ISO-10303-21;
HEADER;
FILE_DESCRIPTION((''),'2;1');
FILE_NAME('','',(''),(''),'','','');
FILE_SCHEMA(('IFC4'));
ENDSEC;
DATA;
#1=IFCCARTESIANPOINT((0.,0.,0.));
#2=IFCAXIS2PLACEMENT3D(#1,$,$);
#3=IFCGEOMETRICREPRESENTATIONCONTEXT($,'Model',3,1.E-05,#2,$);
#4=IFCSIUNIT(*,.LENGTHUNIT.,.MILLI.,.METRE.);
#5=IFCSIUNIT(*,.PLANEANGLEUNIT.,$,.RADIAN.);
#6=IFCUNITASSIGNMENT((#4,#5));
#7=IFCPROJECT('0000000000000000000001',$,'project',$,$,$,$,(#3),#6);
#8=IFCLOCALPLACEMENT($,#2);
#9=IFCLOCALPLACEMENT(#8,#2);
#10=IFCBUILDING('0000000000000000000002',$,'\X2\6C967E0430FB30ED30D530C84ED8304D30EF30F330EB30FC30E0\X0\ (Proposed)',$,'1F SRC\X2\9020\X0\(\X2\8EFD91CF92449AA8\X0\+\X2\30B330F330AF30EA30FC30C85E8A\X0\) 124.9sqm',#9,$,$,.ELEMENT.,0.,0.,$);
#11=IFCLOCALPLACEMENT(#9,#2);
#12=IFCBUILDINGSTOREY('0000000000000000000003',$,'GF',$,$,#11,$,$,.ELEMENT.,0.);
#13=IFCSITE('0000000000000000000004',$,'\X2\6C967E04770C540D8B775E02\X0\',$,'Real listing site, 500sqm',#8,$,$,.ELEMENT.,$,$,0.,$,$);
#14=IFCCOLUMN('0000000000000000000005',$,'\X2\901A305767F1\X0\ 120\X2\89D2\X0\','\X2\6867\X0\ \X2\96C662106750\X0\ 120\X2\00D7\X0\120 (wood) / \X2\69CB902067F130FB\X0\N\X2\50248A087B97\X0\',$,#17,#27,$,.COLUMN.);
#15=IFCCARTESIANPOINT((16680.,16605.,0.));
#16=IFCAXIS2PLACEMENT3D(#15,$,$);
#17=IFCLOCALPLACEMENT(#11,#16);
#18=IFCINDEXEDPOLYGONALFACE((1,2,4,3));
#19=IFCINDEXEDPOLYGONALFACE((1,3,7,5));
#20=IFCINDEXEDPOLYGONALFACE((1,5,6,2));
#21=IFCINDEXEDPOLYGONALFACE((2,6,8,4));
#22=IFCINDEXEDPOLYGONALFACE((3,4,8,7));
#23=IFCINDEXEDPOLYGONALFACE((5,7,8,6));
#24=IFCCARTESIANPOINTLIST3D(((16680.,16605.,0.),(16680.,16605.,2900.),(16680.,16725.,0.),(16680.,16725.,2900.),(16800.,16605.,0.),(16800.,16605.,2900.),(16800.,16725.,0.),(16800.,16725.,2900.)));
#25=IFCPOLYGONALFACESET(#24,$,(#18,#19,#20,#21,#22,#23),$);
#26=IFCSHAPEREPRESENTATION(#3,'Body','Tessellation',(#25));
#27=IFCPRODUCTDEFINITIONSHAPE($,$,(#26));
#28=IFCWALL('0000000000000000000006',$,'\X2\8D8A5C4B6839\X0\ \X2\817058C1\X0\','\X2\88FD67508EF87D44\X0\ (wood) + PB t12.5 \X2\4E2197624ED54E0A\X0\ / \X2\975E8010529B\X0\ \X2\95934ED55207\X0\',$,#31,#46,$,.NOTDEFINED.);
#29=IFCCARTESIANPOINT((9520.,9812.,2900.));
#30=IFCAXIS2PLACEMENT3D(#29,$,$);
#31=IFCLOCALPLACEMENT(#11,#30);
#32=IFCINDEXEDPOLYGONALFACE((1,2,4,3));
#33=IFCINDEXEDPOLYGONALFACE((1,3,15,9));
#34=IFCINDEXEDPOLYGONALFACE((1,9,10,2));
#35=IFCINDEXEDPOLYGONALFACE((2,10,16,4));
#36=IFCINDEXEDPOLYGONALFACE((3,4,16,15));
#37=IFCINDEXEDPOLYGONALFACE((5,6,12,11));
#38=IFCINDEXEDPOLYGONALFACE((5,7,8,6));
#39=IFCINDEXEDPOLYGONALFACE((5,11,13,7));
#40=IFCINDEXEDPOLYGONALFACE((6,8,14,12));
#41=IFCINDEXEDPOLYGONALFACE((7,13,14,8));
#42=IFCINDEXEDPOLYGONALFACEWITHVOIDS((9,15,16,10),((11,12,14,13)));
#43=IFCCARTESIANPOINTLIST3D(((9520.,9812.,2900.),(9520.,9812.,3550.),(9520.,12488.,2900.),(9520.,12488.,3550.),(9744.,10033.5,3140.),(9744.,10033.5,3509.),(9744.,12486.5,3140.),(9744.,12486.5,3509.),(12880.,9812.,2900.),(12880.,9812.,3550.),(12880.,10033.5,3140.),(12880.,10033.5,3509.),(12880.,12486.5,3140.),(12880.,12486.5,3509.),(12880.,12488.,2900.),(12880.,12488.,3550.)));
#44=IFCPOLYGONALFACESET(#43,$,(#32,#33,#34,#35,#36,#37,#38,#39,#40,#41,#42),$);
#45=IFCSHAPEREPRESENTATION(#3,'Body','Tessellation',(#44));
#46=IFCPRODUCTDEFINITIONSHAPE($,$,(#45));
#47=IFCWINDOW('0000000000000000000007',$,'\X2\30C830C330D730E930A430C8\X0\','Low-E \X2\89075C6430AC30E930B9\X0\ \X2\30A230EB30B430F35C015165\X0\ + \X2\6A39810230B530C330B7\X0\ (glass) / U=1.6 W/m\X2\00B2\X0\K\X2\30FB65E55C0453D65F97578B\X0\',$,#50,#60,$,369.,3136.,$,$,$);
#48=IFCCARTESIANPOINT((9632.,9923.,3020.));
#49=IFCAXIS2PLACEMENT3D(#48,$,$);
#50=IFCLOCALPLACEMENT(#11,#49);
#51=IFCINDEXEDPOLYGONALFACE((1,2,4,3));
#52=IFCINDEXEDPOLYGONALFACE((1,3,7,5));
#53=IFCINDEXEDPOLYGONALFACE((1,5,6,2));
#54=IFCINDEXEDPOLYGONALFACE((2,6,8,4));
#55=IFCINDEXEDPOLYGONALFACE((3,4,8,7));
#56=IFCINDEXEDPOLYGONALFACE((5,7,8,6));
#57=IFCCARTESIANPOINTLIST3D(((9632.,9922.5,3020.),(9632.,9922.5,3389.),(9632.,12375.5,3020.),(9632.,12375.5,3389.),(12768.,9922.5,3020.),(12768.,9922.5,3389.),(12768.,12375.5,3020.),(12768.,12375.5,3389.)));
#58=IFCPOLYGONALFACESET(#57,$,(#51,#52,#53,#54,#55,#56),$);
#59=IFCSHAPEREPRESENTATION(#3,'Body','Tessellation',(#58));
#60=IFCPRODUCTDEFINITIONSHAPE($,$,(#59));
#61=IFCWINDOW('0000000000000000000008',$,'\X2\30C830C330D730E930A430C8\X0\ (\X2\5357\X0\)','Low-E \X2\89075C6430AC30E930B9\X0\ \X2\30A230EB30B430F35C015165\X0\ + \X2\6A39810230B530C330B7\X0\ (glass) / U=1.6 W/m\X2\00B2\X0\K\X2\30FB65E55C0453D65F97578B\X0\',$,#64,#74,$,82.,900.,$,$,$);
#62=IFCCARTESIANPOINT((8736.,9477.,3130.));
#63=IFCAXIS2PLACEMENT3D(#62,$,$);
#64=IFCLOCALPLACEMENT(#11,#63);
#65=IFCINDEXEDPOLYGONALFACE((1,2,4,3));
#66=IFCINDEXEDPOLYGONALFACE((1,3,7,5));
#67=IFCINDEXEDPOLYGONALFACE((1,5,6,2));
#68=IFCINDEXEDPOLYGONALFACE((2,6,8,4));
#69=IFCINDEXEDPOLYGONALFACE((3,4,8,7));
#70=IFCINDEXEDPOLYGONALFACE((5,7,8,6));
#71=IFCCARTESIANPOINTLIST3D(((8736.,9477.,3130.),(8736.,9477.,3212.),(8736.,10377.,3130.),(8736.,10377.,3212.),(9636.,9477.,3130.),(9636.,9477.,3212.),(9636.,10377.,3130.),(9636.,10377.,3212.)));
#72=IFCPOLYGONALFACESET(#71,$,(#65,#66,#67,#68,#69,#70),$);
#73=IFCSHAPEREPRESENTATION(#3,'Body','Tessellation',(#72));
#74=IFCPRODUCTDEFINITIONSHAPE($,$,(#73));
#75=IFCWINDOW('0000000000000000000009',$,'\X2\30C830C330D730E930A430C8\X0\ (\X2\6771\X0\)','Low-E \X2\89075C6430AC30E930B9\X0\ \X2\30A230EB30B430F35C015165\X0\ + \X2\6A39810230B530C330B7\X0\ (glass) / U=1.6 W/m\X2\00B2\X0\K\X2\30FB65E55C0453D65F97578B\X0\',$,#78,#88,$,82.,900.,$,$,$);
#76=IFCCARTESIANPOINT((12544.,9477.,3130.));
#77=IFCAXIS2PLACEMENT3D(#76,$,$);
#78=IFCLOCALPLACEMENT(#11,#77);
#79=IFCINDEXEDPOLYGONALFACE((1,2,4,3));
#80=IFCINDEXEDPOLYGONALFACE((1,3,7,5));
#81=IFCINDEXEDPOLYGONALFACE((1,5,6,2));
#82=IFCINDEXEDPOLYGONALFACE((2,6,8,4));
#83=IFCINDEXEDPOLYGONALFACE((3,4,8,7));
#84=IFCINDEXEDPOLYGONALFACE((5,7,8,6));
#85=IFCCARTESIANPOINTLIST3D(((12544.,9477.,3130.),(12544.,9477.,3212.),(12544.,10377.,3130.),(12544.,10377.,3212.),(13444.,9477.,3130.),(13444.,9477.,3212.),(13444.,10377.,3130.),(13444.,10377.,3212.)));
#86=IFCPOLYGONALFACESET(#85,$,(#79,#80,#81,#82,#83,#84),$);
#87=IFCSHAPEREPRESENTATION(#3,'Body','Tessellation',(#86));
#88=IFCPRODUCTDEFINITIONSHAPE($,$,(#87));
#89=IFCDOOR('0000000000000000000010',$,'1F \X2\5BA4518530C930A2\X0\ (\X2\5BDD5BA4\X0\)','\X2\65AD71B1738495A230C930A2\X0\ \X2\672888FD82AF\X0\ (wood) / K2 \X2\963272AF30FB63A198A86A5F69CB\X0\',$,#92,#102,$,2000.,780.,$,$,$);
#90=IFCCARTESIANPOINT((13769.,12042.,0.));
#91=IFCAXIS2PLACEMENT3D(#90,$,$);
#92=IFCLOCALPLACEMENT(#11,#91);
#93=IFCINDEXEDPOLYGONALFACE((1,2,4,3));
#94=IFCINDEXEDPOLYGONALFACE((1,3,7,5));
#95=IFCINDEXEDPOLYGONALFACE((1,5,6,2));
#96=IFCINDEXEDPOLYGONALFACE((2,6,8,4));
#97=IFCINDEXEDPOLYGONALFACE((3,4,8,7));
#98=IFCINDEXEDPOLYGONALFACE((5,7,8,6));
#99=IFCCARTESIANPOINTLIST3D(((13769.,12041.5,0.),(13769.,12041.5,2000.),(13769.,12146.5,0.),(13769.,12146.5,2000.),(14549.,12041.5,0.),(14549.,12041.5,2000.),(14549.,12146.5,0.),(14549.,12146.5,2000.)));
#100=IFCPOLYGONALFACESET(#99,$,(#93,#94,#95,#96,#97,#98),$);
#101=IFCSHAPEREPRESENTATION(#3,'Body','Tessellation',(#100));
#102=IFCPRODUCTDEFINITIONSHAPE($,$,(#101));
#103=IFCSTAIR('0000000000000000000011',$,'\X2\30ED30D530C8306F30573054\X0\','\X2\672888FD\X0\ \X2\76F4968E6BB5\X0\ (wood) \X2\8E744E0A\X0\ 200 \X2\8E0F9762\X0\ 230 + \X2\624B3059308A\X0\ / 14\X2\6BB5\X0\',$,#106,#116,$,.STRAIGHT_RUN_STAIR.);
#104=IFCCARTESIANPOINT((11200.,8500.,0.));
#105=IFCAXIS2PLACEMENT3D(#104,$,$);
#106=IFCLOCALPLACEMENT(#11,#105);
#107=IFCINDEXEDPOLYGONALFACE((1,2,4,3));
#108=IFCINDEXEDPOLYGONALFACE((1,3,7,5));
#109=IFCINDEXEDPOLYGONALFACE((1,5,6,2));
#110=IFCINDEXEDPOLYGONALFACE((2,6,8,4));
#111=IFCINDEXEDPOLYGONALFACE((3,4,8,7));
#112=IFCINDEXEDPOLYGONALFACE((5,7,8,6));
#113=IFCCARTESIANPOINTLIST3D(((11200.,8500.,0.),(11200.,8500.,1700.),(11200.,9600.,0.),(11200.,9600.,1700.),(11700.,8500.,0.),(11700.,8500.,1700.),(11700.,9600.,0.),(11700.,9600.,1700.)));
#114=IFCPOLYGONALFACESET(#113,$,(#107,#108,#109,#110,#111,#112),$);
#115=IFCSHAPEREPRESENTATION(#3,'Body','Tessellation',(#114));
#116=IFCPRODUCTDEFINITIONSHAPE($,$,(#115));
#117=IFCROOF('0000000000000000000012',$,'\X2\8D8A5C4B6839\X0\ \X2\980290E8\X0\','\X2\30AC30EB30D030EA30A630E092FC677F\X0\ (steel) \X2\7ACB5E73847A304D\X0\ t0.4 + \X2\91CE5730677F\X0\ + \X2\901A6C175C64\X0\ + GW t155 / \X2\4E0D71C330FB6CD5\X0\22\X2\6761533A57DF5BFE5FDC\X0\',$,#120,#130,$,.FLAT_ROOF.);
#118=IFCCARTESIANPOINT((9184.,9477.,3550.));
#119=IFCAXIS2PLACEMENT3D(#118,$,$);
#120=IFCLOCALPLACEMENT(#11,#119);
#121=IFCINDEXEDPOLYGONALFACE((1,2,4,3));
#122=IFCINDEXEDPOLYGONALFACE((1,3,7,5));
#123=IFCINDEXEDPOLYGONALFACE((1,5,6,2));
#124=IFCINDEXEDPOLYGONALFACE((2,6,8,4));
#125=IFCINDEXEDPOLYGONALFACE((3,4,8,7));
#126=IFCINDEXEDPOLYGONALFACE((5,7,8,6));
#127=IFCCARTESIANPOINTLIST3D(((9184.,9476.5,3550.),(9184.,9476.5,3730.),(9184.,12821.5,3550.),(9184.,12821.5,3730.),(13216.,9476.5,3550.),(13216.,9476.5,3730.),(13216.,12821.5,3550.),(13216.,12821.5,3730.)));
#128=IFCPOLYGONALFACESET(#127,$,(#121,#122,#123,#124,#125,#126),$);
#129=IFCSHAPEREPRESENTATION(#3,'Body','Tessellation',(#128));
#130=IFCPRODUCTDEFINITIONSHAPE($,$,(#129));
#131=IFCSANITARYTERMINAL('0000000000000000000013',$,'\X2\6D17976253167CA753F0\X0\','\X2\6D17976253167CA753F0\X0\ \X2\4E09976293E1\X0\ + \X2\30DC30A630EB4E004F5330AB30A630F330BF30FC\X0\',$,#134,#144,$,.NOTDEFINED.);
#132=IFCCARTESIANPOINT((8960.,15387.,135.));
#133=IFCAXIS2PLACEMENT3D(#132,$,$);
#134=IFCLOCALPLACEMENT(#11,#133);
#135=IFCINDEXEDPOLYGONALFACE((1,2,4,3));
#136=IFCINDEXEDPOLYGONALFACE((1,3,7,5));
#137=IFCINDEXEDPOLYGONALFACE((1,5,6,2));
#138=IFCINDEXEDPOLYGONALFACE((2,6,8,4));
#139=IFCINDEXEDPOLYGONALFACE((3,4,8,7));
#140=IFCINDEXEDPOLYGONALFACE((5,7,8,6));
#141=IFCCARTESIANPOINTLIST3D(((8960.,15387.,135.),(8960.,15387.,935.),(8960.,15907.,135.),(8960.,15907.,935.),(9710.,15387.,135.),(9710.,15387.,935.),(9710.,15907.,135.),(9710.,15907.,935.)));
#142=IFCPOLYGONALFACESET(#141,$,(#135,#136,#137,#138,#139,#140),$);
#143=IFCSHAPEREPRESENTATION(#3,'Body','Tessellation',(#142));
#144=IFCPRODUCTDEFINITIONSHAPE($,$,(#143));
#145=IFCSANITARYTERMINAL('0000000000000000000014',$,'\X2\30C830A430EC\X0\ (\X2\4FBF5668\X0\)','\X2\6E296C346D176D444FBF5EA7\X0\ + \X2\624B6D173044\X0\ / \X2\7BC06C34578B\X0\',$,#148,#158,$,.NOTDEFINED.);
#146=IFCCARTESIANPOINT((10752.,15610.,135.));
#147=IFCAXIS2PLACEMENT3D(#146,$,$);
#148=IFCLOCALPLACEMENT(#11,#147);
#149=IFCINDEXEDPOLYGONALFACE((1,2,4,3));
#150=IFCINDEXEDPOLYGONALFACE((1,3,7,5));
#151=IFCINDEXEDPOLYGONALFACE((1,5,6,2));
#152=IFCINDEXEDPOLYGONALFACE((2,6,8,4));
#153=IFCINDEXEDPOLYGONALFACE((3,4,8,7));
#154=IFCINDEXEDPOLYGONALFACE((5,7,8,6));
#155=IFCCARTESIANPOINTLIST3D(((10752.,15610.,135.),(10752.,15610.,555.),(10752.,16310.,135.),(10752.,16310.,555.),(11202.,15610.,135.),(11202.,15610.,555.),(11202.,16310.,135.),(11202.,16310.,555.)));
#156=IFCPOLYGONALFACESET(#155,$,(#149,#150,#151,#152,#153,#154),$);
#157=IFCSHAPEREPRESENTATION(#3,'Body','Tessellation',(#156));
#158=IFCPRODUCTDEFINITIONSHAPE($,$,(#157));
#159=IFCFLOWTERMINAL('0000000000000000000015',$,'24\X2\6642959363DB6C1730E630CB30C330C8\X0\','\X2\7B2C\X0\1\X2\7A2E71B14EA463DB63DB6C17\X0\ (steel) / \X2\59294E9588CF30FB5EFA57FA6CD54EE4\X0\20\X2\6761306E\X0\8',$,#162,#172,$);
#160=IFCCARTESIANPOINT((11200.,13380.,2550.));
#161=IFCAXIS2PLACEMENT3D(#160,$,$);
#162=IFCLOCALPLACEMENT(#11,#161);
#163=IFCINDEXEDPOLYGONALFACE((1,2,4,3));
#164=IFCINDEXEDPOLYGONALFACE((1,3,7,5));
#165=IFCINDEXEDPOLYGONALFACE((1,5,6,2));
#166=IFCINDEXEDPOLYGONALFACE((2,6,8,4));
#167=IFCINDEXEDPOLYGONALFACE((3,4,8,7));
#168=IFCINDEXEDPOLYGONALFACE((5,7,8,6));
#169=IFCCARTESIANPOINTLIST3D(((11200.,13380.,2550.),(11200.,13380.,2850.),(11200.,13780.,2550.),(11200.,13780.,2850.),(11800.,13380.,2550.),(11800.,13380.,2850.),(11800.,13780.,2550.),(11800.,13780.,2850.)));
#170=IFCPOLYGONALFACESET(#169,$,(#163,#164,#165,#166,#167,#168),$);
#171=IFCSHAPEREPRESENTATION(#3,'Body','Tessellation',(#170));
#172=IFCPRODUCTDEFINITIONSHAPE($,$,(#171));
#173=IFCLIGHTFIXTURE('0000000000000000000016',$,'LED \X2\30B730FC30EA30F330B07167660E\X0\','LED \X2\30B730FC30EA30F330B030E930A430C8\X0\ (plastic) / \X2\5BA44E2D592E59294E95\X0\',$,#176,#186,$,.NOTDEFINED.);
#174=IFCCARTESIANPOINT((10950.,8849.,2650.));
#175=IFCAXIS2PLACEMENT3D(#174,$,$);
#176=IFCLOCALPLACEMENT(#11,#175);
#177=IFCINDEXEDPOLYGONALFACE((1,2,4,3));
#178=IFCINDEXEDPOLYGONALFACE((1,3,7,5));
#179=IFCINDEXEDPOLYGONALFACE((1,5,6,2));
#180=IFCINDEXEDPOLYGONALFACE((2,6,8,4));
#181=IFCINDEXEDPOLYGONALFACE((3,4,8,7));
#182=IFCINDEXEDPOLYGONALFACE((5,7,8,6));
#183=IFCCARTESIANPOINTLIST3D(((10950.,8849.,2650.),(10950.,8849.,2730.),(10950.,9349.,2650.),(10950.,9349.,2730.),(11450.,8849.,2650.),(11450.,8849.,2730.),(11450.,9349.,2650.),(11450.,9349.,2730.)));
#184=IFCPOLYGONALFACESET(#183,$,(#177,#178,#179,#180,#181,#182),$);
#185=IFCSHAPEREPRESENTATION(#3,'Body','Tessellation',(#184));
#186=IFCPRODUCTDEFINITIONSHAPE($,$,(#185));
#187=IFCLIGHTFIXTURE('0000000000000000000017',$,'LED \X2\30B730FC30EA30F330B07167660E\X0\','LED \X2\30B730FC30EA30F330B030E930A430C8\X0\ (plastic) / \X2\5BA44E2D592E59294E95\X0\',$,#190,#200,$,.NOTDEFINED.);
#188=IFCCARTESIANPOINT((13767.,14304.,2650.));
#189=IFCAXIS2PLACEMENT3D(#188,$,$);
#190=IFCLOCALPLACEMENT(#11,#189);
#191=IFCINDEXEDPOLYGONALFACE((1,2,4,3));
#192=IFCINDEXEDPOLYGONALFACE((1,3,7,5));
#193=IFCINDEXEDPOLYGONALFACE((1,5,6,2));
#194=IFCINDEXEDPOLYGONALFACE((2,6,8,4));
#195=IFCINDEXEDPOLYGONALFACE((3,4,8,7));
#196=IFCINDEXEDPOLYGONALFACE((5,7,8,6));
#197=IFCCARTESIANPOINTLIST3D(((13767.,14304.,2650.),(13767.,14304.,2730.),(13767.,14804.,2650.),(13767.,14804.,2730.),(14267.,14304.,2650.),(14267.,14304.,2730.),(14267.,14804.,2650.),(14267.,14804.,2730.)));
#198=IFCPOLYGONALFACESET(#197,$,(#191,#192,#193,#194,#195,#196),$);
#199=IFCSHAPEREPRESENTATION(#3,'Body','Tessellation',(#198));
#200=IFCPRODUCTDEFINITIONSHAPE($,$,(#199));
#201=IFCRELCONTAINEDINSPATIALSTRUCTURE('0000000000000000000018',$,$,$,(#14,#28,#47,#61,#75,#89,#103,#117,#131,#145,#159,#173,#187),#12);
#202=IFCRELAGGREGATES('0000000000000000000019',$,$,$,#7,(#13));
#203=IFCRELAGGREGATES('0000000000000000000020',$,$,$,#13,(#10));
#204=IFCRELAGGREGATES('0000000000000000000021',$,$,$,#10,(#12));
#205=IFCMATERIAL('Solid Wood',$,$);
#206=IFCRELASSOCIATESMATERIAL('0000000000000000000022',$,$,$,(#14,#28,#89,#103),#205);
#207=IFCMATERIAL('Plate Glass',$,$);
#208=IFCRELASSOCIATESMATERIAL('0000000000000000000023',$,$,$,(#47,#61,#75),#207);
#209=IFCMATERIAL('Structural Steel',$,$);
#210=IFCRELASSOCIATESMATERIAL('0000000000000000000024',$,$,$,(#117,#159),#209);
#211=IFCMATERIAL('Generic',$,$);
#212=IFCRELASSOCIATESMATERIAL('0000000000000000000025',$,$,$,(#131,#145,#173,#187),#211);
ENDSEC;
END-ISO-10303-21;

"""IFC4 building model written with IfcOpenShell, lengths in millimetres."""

from ifc_helpers import new_model, si_unit, frame, frame_2d, origin, place, context, project, spatial, rectangle, extrude, material, element, fill, save


model = new_model("IFC4")

# Units and contexts
model_context = context("Model", 3, precision=1e-05, world=origin())
ifc_project = project(units=[si_unit("LENGTHUNIT", "METRE", prefix="MILLI"), si_unit("PLANEANGLEUNIT", "RADIAN")], contexts=[model_context])

# Site, building, storey
site_placement = place(None, origin())
site = spatial("IfcSite", under=ifc_project, at=site_placement, Name="沖縄県名護市", ObjectType="Real listing site, 500sqm", CompositionType="ELEMENT", RefElevation=0.0)
building_placement = place(site_placement, origin())
building = spatial("IfcBuilding", under=site, at=building_placement, Name="沖縄・ロフト付きワンルーム (Proposed)", ObjectType="1F SRC造(軽量鉄骨+コンクリート床) 124.9sqm", CompositionType="ELEMENT", ElevationOfRefHeight=0.0, ElevationOfTerrain=0.0)
storey_placement = place(building_placement, origin())
storey = spatial("IfcBuildingStorey", under=building, at=storey_placement, Name="GF", CompositionType="ELEMENT", Elevation=0.0)

# Column
ifc_material_1 = material(Name="Solid Wood")
column_1_placement = place(storey_placement, frame((16680.0, 16605.0, 0.0)))
element("IfcColumn", 1, at=column_1_placement, inside=storey, material=ifc_material_1, Name="通し柱 120角", Description="桧 集成材 120×120 (wood) / 構造柱・N値計算", PredefinedType="COLUMN", context=model_context, shape_type="SweptSolid", body=[
    extrude(rectangle(XDim=120.0, YDim=120.0, at=frame_2d((60.0, 60.0))), frame((16680.0, 16605.0, 0.0)), (0.0, 0.0, 1.0), 2900.0),
])

# Wall, openings, windows
wall_1_placement = place(storey_placement, frame((9520.0, 9812.0, 2900.0)))
wall_1 = element("IfcWall", 2, at=wall_1_placement, inside=storey, material=ifc_material_1, Name="越屋根 腰壁", Description="製材軸組 (wood) + PB t12.5 両面仕上 / 非耐力 間仕切", PredefinedType="NOTDEFINED", context=model_context, shape_type="SweptSolid", body=[
    extrude(rectangle(XDim=3360.0, YDim=2676.0, at=frame_2d((1680.0, 1338.0))), frame((9520.0, 9812.0, 2900.0)), (0.0, 0.0, 1.0), 650.0),
])
opening_1_placement = place(storey_placement, frame((9632.0, 9923.0, 3020.0)))
opening_1 = element("IfcOpeningElement", 3, at=opening_1_placement, cuts=wall_1, PredefinedType="NOTDEFINED", context=model_context, shape_type="SweptSolid", body=[
    extrude(rectangle(XDim=3136.0, YDim=2453.0, at=frame_2d((1568.0, 1226.0))), frame((9632.0, 9923.0, 3020.0)), (0.0, 0.0, 1.0), 369.0),
])
opening_2_placement = place(storey_placement, frame((8736.0, 9477.0, 3130.0)))
opening_2 = element("IfcOpeningElement", 4, at=opening_2_placement, cuts=wall_1, PredefinedType="NOTDEFINED", context=model_context, shape_type="SweptSolid", body=[
    extrude(rectangle(XDim=900.0, YDim=900.0, at=frame_2d((450.0, 450.0))), frame((8736.0, 9477.0, 3130.0)), (0.0, 0.0, 1.0), 82.0),
])
opening_3_placement = place(storey_placement, frame((12544.0, 9477.0, 3130.0)))
opening_3 = element("IfcOpeningElement", 5, at=opening_3_placement, cuts=wall_1, PredefinedType="NOTDEFINED", context=model_context, shape_type="SweptSolid", body=[
    extrude(rectangle(XDim=900.0, YDim=900.0, at=frame_2d((450.0, 450.0))), frame((12544.0, 9477.0, 3130.0)), (0.0, 0.0, 1.0), 82.0),
])
ifc_material_2 = material(Name="Plate Glass")
window_1_placement = place(storey_placement, frame((9632.0, 9923.0, 3020.0)))
window_1 = element("IfcWindow", 6, at=window_1_placement, inside=storey, material=ifc_material_2, Name="トップライト", Description="Low-E 複層ガラス アルゴン封入 + 樹脂サッシ (glass) / U=1.6 W/m²K・日射取得型", OverallHeight=369.0, OverallWidth=3136.0, context=model_context, shape_type="SweptSolid", body=[
    extrude(rectangle(XDim=3136.0, YDim=2453.0, at=frame_2d((1568.0, 1226.0))), frame((9632.0, 9923.0, 3020.0)), (0.0, 0.0, 1.0), 369.0),
])
fill(opening_1, window_1)
window_2_placement = place(storey_placement, frame((8736.0, 9477.0, 3130.0)))
window_2 = element("IfcWindow", 7, at=window_2_placement, inside=storey, material=ifc_material_2, Name="トップライト (南)", Description="Low-E 複層ガラス アルゴン封入 + 樹脂サッシ (glass) / U=1.6 W/m²K・日射取得型", OverallHeight=82.0, OverallWidth=900.0, context=model_context, shape_type="SweptSolid", body=[
    extrude(rectangle(XDim=900.0, YDim=900.0, at=frame_2d((450.0, 450.0))), frame((8736.0, 9477.0, 3130.0)), (0.0, 0.0, 1.0), 82.0),
])
fill(opening_2, window_2)
window_3_placement = place(storey_placement, frame((12544.0, 9477.0, 3130.0)))
window_3 = element("IfcWindow", 8, at=window_3_placement, inside=storey, material=ifc_material_2, Name="トップライト (東)", Description="Low-E 複層ガラス アルゴン封入 + 樹脂サッシ (glass) / U=1.6 W/m²K・日射取得型", OverallHeight=82.0, OverallWidth=900.0, context=model_context, shape_type="SweptSolid", body=[
    extrude(rectangle(XDim=900.0, YDim=900.0, at=frame_2d((450.0, 450.0))), frame((12544.0, 9477.0, 3130.0)), (0.0, 0.0, 1.0), 82.0),
])
fill(opening_3, window_3)

# Door
door_placement = place(storey_placement, frame((13769.0, 12042.0, 0.0)))
element("IfcDoor", 9, at=door_placement, inside=storey, material=ifc_material_1, Name="1F 室内ドア (寝室)", Description="断熱玄関ドア 木製芯 (wood) / K2 防犯・採風機構", OverallHeight=2000.0, OverallWidth=780.0, context=model_context, shape_type="SweptSolid", body=[
    extrude(rectangle(XDim=780.0, YDim=105.0, at=frame_2d((390.0, 52.0))), frame((13769.0, 12042.0, 0.0)), (0.0, 0.0, 1.0), 2000.0),
])

# Stair
stair_placement = place(storey_placement, frame((11200.0, 8500.0, 0.0)))
element("IfcStair", 10, at=stair_placement, inside=storey, material=ifc_material_1, Name="ロフトはしご", Description="木製 直階段 (wood) 蹴上 200 踏面 230 + 手すり / 14段", PredefinedType="STRAIGHT_RUN_STAIR", context=model_context, shape_type="SweptSolid", body=[
    extrude(rectangle(XDim=500.0, YDim=1100.0, at=frame_2d((250.0, 550.0))), frame((11200.0, 8500.0, 0.0)), (0.0, 0.0, 1.0), 1700.0),
])

# Roof
ifc_material_3 = material(Name="Structural Steel")
roof_placement = place(storey_placement, frame((9184.0, 9477.0, 3550.0)))
element("IfcRoof", 11, at=roof_placement, inside=storey, material=ifc_material_3, Name="越屋根 頂部", Description="ガルバリウム鋼板 (steel) 立平葺き t0.4 + 野地板 + 通気層 + GW t155 / 不燃・法22条区域対応", PredefinedType="FLAT_ROOF", context=model_context, shape_type="SweptSolid", body=[
    extrude(rectangle(XDim=4032.0, YDim=3345.0, at=frame_2d((2016.0, 1672.0))), frame((9184.0, 9477.0, 3550.0)), (0.0, 0.0, 1.0), 180.0),
])

# Sanitary terminals
ifc_material_4 = material(Name="Generic")
sanitary_terminal_1_placement = place(storey_placement, frame((8960.0, 15387.0, 135.0)))
element("IfcSanitaryTerminal", 12, at=sanitary_terminal_1_placement, inside=storey, material=ifc_material_4, Name="洗面化粧台", Description="洗面化粧台 三面鏡 + ボウル一体カウンター", PredefinedType="NOTDEFINED", context=model_context, shape_type="SweptSolid", body=[
    extrude(rectangle(XDim=750.0, YDim=520.0, at=frame_2d((375.0, 260.0))), frame((8960.0, 15387.0, 135.0)), (0.0, 0.0, 1.0), 800.0),
])
sanitary_terminal_2_placement = place(storey_placement, frame((10752.0, 15610.0, 135.0)))
element("IfcSanitaryTerminal", 13, at=sanitary_terminal_2_placement, inside=storey, material=ifc_material_4, Name="トイレ (便器)", Description="温水洗浄便座 + 手洗い / 節水型", PredefinedType="NOTDEFINED", context=model_context, shape_type="SweptSolid", body=[
    extrude(rectangle(XDim=450.0, YDim=700.0, at=frame_2d((225.0, 350.0))), frame((10752.0, 15610.0, 135.0)), (0.0, 0.0, 1.0), 420.0),
])

# Flow terminal
flow_terminal_placement = place(storey_placement, frame((11200.0, 13380.0, 2550.0)))
element("IfcFlowTerminal", 14, at=flow_terminal_placement, inside=storey, material=ifc_material_3, Name="24時間換気ユニット", Description="第1種熱交換換気 (steel) / 天井裏・建基法令20条の8", context=model_context, shape_type="SweptSolid", body=[
    extrude(rectangle(XDim=600.0, YDim=400.0, at=frame_2d((300.0, 200.0))), frame((11200.0, 13380.0, 2550.0)), (0.0, 0.0, 1.0), 300.0),
])

# Light fixtures
light_fixture_1_placement = place(storey_placement, frame((10950.0, 8849.0, 2650.0)))
element("IfcLightFixture", 15, at=light_fixture_1_placement, inside=storey, material=ifc_material_4, Name="LED シーリング照明", Description="LED シーリングライト (plastic) / 室中央天井", PredefinedType="NOTDEFINED", context=model_context, shape_type="SweptSolid", body=[
    extrude(rectangle(XDim=500.0, YDim=500.0, at=frame_2d((250.0, 250.0))), frame((10950.0, 8849.0, 2650.0)), (0.0, 0.0, 1.0), 80.0),
])
light_fixture_2_placement = place(storey_placement, frame((13767.0, 14304.0, 2650.0)))
element("IfcLightFixture", 16, at=light_fixture_2_placement, inside=storey, material=ifc_material_4, Name="LED シーリング照明", Description="LED シーリングライト (plastic) / 室中央天井", PredefinedType="NOTDEFINED", context=model_context, shape_type="SweptSolid", body=[
    extrude(rectangle(XDim=500.0, YDim=500.0, at=frame_2d((250.0, 250.0))), frame((13767.0, 14304.0, 2650.0)), (0.0, 0.0, 1.0), 80.0),
])

save(model, "model.ifc")
